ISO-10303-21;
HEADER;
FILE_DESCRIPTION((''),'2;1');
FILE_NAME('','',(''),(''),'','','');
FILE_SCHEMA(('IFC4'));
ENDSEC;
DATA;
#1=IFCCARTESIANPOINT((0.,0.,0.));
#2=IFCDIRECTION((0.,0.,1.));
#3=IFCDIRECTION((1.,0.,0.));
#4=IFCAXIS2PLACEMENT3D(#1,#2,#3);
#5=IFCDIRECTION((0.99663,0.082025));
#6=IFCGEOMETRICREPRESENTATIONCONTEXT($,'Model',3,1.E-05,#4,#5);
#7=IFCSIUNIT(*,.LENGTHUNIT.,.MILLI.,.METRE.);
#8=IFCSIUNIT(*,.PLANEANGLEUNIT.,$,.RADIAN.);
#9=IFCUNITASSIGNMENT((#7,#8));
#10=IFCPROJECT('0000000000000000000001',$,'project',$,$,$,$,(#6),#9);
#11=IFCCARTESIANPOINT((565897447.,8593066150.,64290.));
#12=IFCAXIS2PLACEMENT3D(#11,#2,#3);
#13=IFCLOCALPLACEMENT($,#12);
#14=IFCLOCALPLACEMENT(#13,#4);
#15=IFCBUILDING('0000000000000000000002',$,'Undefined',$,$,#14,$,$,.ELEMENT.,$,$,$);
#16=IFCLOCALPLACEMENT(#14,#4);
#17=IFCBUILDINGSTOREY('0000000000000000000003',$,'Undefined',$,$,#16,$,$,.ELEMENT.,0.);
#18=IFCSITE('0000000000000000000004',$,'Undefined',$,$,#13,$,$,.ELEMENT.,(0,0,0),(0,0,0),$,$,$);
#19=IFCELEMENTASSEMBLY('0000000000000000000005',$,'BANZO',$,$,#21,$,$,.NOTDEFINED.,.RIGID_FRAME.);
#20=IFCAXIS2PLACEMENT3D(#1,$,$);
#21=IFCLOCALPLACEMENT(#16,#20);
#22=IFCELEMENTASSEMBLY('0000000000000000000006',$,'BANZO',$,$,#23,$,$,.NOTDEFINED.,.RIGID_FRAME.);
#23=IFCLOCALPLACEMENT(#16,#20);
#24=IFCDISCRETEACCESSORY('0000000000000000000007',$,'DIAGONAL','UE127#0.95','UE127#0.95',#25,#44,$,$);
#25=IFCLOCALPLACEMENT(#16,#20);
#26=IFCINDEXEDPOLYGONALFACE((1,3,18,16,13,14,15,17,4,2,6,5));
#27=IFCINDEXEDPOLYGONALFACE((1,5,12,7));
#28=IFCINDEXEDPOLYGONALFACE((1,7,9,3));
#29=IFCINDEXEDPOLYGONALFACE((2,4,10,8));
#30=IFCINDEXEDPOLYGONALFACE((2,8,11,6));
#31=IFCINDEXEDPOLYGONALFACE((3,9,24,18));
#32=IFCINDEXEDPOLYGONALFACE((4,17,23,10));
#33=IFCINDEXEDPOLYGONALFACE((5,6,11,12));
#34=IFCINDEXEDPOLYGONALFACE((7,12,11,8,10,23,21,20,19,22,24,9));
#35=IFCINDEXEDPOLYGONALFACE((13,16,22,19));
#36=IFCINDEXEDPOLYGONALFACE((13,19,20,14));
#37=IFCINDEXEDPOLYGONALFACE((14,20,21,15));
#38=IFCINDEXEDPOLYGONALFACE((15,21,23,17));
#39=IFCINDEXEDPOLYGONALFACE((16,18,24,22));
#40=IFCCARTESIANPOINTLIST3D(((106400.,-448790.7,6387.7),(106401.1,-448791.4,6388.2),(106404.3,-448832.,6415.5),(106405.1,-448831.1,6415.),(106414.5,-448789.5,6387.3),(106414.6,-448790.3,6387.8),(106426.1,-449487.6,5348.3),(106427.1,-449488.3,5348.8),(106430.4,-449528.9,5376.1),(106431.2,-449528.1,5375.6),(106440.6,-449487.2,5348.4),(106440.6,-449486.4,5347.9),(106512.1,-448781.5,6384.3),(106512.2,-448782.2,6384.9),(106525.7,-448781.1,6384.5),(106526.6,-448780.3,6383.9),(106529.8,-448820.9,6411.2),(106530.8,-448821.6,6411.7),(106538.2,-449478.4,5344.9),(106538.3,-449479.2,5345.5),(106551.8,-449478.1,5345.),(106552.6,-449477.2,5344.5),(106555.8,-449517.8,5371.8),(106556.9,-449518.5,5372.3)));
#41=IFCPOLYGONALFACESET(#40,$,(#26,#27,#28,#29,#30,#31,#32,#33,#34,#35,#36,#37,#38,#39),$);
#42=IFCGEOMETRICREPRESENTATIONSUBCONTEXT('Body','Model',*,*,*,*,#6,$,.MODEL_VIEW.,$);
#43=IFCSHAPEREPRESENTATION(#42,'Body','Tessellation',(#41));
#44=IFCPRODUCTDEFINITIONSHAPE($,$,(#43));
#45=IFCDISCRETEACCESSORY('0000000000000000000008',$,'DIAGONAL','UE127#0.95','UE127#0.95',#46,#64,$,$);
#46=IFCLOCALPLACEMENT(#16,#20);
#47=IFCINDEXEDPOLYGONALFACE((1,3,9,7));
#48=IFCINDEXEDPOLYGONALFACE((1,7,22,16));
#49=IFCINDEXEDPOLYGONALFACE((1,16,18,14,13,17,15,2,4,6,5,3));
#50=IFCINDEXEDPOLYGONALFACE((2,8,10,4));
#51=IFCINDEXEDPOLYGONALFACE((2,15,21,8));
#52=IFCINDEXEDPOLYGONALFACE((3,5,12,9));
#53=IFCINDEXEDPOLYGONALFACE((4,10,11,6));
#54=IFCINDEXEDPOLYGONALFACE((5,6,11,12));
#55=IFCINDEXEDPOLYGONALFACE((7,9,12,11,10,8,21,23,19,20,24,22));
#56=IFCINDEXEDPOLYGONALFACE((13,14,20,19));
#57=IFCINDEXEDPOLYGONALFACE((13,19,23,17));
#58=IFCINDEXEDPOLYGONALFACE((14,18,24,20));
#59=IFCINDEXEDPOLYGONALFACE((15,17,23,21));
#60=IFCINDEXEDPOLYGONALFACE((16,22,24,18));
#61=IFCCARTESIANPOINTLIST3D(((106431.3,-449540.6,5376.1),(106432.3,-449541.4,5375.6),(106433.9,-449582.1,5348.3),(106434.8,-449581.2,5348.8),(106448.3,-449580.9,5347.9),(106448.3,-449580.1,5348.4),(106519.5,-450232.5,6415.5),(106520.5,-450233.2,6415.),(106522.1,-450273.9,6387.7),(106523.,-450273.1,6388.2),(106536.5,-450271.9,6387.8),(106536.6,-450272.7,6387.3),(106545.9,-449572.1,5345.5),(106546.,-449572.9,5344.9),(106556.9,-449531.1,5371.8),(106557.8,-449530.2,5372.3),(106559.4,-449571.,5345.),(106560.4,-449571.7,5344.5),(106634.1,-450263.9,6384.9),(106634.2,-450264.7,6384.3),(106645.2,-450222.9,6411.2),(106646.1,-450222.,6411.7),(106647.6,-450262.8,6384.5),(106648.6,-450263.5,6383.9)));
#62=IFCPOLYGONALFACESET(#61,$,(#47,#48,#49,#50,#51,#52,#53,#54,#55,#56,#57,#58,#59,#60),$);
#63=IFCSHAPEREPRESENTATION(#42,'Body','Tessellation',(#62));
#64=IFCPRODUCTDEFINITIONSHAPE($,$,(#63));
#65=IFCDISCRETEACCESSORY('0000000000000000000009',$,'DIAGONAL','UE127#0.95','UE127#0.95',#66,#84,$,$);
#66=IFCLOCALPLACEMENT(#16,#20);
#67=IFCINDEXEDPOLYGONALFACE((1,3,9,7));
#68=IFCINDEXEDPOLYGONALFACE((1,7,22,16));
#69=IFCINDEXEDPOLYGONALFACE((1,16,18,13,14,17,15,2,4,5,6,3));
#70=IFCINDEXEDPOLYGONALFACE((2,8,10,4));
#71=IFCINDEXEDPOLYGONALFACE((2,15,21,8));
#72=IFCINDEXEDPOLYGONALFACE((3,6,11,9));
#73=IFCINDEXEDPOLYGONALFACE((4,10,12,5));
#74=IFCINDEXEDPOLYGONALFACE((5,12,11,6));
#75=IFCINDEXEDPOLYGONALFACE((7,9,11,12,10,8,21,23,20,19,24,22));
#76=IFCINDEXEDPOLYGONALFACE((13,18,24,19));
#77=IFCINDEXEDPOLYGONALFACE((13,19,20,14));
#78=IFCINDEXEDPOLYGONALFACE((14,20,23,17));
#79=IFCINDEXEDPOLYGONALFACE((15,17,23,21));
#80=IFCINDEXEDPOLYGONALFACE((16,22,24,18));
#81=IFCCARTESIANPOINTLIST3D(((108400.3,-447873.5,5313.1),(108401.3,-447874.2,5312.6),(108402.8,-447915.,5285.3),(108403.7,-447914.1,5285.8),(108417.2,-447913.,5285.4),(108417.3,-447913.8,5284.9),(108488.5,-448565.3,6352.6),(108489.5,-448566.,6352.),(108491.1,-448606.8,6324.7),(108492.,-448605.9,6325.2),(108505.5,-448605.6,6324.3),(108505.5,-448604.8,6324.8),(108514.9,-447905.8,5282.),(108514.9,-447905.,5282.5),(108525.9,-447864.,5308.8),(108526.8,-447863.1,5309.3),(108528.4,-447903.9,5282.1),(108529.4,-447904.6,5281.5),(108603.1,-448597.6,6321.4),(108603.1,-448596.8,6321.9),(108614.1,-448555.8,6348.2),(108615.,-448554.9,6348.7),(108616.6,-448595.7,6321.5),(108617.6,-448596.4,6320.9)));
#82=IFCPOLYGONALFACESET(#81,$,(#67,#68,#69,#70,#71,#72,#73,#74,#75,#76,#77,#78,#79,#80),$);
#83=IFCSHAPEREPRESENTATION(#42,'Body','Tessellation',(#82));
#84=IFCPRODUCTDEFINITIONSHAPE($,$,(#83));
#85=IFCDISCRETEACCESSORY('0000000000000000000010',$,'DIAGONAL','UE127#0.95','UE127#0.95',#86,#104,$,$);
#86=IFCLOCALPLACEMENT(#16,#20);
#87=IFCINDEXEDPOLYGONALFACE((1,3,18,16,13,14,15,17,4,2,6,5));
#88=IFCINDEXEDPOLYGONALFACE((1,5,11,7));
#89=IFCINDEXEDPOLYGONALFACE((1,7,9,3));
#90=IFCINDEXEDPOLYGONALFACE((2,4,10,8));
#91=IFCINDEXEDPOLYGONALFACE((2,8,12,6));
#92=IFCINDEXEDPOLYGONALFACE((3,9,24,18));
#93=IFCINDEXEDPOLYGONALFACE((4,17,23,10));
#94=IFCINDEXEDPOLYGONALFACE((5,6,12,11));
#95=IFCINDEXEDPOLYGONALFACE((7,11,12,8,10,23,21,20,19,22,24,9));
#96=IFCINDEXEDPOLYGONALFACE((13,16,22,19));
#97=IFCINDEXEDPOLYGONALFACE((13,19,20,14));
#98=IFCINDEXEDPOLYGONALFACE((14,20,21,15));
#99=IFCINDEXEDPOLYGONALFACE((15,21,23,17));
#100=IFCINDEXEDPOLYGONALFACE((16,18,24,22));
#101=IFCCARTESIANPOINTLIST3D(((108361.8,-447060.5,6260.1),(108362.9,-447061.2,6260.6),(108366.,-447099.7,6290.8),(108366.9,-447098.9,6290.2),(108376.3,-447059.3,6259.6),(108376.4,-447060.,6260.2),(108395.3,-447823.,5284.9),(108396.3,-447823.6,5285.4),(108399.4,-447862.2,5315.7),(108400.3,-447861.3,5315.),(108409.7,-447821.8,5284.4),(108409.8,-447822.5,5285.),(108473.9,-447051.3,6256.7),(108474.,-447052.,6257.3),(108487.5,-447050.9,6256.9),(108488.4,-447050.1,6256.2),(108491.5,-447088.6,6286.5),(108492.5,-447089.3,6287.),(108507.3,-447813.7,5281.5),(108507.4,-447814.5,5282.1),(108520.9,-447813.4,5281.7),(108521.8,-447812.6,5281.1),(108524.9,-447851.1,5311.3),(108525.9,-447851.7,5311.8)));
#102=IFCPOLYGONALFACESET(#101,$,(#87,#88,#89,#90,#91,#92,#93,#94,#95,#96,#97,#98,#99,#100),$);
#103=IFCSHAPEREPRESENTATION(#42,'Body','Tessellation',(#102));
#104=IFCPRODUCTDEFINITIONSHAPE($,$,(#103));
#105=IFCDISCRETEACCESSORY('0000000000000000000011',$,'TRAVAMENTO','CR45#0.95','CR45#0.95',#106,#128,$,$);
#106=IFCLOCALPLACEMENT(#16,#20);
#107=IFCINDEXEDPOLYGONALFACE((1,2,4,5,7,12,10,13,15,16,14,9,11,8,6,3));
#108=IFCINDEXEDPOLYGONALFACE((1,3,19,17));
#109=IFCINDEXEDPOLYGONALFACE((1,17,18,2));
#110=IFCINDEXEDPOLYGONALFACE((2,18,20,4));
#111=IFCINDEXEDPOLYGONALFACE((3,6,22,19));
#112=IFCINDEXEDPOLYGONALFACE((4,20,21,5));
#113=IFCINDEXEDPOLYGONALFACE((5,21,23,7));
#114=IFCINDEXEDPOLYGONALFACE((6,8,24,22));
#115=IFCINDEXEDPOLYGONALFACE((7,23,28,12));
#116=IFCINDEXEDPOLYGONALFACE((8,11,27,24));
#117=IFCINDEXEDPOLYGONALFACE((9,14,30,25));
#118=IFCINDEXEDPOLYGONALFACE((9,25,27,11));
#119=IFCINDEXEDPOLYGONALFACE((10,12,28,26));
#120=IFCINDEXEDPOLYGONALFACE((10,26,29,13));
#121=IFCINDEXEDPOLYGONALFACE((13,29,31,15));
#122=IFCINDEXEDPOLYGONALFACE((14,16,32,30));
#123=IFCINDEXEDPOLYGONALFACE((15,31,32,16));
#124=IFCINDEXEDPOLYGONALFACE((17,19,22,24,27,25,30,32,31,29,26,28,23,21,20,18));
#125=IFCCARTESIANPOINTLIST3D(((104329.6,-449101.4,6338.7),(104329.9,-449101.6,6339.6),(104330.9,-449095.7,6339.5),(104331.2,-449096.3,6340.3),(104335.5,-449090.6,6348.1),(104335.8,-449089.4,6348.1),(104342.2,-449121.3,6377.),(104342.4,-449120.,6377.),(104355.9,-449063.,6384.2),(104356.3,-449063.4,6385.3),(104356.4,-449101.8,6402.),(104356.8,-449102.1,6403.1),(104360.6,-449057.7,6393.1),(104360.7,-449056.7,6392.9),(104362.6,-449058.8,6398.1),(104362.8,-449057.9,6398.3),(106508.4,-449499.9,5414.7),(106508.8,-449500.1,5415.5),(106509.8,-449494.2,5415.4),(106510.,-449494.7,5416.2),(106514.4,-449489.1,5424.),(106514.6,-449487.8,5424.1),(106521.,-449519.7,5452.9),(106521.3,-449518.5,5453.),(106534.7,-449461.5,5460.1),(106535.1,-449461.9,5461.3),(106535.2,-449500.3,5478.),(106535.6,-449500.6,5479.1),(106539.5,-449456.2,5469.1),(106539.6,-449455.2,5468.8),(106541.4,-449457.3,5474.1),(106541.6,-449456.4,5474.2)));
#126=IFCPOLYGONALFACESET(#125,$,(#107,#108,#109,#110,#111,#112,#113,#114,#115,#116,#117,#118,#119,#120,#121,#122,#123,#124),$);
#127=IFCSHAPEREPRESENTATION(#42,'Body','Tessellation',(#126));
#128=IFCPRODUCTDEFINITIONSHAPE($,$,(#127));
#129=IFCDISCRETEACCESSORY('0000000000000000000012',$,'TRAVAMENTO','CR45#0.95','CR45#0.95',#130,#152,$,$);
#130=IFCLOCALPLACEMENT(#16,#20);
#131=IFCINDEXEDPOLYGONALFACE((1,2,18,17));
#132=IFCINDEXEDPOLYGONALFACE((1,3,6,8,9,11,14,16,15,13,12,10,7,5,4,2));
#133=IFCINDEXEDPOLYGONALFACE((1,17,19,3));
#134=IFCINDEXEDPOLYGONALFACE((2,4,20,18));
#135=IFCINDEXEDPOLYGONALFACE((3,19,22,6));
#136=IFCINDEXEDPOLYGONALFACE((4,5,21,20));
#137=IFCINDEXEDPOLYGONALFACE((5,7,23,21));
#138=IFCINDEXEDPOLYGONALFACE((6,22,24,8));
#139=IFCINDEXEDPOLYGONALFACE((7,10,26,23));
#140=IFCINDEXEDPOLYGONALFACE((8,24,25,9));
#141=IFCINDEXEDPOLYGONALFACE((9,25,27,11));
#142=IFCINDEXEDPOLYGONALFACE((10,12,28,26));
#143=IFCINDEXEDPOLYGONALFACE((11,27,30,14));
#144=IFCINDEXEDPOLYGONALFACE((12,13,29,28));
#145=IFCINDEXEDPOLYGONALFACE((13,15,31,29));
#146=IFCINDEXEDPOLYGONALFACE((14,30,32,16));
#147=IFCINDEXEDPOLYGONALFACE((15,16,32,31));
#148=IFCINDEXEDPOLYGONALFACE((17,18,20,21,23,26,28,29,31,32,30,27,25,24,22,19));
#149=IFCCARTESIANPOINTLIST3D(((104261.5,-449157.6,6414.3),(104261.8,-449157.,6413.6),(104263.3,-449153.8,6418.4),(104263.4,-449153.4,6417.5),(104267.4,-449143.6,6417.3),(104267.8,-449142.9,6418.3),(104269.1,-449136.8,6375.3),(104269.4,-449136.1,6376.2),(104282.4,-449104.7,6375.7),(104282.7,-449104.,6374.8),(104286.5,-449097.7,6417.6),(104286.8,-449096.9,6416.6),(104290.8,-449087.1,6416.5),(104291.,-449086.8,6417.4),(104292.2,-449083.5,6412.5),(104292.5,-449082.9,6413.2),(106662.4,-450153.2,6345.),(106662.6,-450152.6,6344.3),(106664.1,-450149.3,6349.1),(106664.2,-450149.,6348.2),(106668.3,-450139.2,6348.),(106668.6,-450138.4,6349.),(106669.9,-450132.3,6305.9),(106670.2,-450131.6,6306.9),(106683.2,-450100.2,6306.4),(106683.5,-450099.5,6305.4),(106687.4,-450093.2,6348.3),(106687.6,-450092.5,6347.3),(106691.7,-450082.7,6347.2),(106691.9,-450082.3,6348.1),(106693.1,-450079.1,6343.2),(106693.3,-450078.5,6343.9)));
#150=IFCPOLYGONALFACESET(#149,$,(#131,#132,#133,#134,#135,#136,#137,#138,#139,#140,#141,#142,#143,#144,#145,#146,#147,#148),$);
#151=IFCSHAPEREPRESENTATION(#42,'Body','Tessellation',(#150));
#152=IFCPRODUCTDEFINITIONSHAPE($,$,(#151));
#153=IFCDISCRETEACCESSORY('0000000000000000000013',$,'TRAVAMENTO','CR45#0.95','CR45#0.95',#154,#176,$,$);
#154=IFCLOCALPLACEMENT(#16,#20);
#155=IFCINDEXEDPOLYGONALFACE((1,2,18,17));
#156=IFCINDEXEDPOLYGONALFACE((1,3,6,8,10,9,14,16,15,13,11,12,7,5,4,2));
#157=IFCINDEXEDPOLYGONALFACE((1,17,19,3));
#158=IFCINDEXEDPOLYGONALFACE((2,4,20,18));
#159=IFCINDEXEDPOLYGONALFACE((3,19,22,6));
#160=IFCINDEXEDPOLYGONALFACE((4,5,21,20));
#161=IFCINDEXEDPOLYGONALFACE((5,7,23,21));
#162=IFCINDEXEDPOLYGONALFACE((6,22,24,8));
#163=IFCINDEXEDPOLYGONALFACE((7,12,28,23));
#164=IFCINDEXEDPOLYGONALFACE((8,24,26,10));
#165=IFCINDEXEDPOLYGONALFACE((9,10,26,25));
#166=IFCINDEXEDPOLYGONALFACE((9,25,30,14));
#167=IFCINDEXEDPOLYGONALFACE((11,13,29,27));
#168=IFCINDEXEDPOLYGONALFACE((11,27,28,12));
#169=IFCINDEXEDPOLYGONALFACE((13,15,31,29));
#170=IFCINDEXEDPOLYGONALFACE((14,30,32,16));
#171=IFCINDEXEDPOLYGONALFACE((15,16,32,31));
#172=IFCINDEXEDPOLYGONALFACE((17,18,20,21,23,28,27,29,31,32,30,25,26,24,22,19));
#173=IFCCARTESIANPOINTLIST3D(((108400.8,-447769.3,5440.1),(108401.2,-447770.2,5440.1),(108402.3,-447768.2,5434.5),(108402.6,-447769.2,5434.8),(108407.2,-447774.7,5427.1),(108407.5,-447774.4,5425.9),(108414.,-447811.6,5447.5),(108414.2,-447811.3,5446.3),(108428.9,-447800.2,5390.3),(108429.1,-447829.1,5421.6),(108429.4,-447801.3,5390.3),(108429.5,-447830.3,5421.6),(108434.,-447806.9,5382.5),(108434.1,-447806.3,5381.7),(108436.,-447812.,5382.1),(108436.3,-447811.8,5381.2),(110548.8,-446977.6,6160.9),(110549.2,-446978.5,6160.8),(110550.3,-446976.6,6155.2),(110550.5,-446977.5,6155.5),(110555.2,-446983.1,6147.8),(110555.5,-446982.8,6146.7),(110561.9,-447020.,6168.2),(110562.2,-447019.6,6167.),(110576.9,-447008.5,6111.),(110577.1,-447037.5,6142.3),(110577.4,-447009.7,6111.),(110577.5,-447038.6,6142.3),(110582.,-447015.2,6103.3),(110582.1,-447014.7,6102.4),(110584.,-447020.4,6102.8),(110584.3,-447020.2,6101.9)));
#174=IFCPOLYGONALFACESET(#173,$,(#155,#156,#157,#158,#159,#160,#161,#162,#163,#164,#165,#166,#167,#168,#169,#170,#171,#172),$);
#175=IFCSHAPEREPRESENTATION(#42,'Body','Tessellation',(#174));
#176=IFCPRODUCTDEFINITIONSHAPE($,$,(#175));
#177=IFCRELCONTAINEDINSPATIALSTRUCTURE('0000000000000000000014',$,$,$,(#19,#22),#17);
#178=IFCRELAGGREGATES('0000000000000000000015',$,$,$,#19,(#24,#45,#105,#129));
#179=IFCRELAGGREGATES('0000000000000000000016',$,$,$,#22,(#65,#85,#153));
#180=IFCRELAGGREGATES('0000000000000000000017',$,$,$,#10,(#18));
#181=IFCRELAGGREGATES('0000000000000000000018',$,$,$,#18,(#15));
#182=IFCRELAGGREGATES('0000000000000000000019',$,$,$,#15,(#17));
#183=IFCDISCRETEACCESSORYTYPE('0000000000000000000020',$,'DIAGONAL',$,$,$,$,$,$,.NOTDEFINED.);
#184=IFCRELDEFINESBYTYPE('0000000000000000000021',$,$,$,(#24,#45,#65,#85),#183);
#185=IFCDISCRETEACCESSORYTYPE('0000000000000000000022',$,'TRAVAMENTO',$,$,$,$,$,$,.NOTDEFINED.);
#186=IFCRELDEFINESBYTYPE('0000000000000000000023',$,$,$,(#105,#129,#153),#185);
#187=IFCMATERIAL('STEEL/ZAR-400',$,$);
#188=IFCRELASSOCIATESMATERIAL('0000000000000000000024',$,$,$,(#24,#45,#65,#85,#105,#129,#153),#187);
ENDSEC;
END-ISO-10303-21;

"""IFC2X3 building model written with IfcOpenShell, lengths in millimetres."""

from ifc_helpers import new_model, si_unit, direction, frame, frame_2d, origin_with_axes, place, context, subcontext, project, spatial, polyline, c_section, outline, extrude, material, type_object, element, aggregate, save


model = new_model("IFC2X3")

# Units and contexts
model_context = context("Model", 3, precision=1e-05, world=origin_with_axes(), true_north=direction((0.99663, 0.082025)))
body_context = subcontext(model_context, "Body", "Model", "MODEL_VIEW")
ifc_project = project(units=[si_unit("LENGTHUNIT", "METRE", prefix="MILLI"), si_unit("PLANEANGLEUNIT", "RADIAN")], contexts=[model_context])

# Site, building, storey
site_placement = place(None, frame((565897447.0, 8593066150.0, 64290.0), z_axis=(0.0, 0.0, 1.0), x_axis=(1.0, 0.0, 0.0)))
site = spatial("IfcSite", under=ifc_project, at=site_placement, Name="Undefined", CompositionType="ELEMENT", RefLatitude=(0, 0, 0), RefLongitude=(0, 0, 0))
building_placement = place(site_placement, origin_with_axes())
building = spatial("IfcBuilding", under=site, at=building_placement, Name="Undefined", CompositionType="ELEMENT")
storey_placement = place(building_placement, origin_with_axes())
storey = spatial("IfcBuildingStorey", under=building, at=storey_placement, Name="Undefined", CompositionType="ELEMENT", Elevation=0.0)

# Shared definitions
ifc_material_1 = material(Name="STEEL/ZAR-400")

# Element assemblies
assembly_1_placement = place(storey_placement, origin_with_axes())
assembly_1 = element("IfcElementAssembly", 1, at=assembly_1_placement, inside=storey, Name="BANZO", AssemblyPlace="NOTDEFINED", PredefinedType="RIGID_FRAME")
assembly_2_placement = place(storey_placement, origin_with_axes())
assembly_2 = element("IfcElementAssembly", 2, at=assembly_2_placement, inside=storey, Name="BANZO", AssemblyPlace="NOTDEFINED", PredefinedType="RIGID_FRAME")

# Discrete accessories
discrete_accessory_type_1 = type_object("IfcDiscreteAccessoryType", Name="DIAGONAL")
discrete_accessory_1_placement = place(assembly_1_placement, frame((106465.4, -448806.1, 6399.7), z_axis=(-0.996182, -0.081989, 0.029987), x_axis=(0.020829, -0.556784, -0.830396)))
discrete_accessory_1 = element("IfcDiscreteAccessory", 3, at=discrete_accessory_1_placement, type_object=discrete_accessory_type_1, material=ifc_material_1, Name="DIAGONAL", Description="UE127#0.95", ObjectType="UE127#0.95", context=body_context, shape_type="SweptSolid", body=[
    extrude(c_section(Depth=127.0, Width=50.0, WallThickness=0.9, Girth=14.5, at=frame_2d((0.0, 0.0), x_axis=(1.0, 0.0))), frame((1251.7, 0.0, 0.0), z_axis=(-1.0, 0.0, 0.0), x_axis=(0.0, -1.0, 0.0)), (0.0, 0.0, 1.0), 1251.7),
])
discrete_accessory_2_placement = place(assembly_1_placement, frame((106495.9, -449556.2, 5360.3), z_axis=(-0.996182, -0.081989, 0.029987), x_axis=(0.070485, -0.552697, 0.830396)))
discrete_accessory_2 = element("IfcDiscreteAccessory", 4, at=discrete_accessory_2_placement, type_object=discrete_accessory_type_1, material=ifc_material_1, Name="DIAGONAL", Description="UE127#0.95", ObjectType="UE127#0.95", context=body_context, shape_type="SweptSolid", body=[
    extrude(c_section(Depth=127.0, Width=50.0, WallThickness=0.9, Girth=14.5, at=frame_2d((0.0, 0.0), x_axis=(1.0, 0.0))), frame((1251.7, 0.0, 0.0), z_axis=(-1.0, 0.0, 0.0), x_axis=(0.0, -1.0, 0.0)), (0.0, 0.0, 1.0), 1251.7),
])
discrete_accessory_3_placement = place(assembly_2_placement, frame((108464.8, -447889.0, 5297.3), z_axis=(-0.996182, -0.081989, 0.029987), x_axis=(0.070485, -0.552697, 0.830396)))
discrete_accessory_3 = element("IfcDiscreteAccessory", 5, at=discrete_accessory_3_placement, type_object=discrete_accessory_type_1, material=ifc_material_1, Name="DIAGONAL", Description="UE127#0.95", ObjectType="UE127#0.95", context=body_context, shape_type="SweptSolid", body=[
    extrude(c_section(Depth=127.0, Width=50.0, WallThickness=0.9, Girth=14.5, at=frame_2d((0.0, 0.0), x_axis=(1.0, 0.0))), frame((1251.7, 0.0, 0.0), z_axis=(-1.0, 0.0, 0.0), x_axis=(0.0, -1.0, 0.0)), (0.0, 0.0, 1.0), 1251.7),
])
discrete_accessory_4_placement = place(assembly_2_placement, frame((108427.2, -447074.9, 6273.5), z_axis=(-0.996182, -0.081989, 0.029987), x_axis=(0.026972, -0.615733, -0.787493)))
discrete_accessory_4 = element("IfcDiscreteAccessory", 6, at=discrete_accessory_4_placement, type_object=discrete_accessory_type_1, material=ifc_material_1, Name="DIAGONAL", Description="UE127#0.95", ObjectType="UE127#0.95", context=body_context, shape_type="SweptSolid", body=[
    extrude(c_section(Depth=127.0, Width=50.0, WallThickness=0.9, Girth=14.5, at=frame_2d((0.0, 0.0), x_axis=(1.0, 0.0))), frame((1238.3, 0.0, 0.0), z_axis=(-1.0, 0.0, 0.0), x_axis=(0.0, -1.0, 0.0)), (0.0, 0.0, 1.0), 1238.3),
])
discrete_accessory_type_2 = type_object("IfcDiscreteAccessoryType", Name="TRAVAMENTO")
discrete_accessory_5_placement = place(assembly_1_placement, frame((106526.4, -449492.6, 5453.8), z_axis=(0.084779, -0.826601, 0.556366), x_axis=(-0.907854, 0.16603, 0.385013)))
discrete_accessory_5 = element("IfcDiscreteAccessory", 7, at=discrete_accessory_5_placement, type_object=discrete_accessory_type_2, material=ifc_material_1, Name="TRAVAMENTO", Description="CR45#0.95", ObjectType="CR45#0.95", context=body_context, shape_type="SweptSolid", body=[
    extrude(outline(polyline([(-35.5, -20.5), (-24.9, -20.5), (-17.4, 21.5), (18.1, 21.5), (25.6, -20.5), (36.2, -20.5), (40.1, -16.6), (40.8, -17.3), (36.6, -21.5), (24.8, -21.5), (17.3, 20.5), (-16.6, 20.5), (-24.1, -21.5), (-35.9, -21.5), (-40.1, -17.3), (-39.4, -16.6), (-35.5, -20.5)])), frame((2400.0, 0.0, 0.0), z_axis=(-1.0, 0.0, 0.0), x_axis=(0.0, -1.0, 0.0)), (0.0, 0.0, 1.0), 2400.0),
])
discrete_accessory_6_placement = place(assembly_1_placement, frame((106677.5, -450115.6, 6327.1), z_axis=(-0.029884, -0.00246, -0.99955), x_axis=(-0.923403, 0.382903, 0.026665)))
discrete_accessory_6 = element("IfcDiscreteAccessory", 8, at=discrete_accessory_6_placement, type_object=discrete_accessory_type_2, material=ifc_material_1, Name="TRAVAMENTO", Description="CR45#0.95", ObjectType="CR45#0.95", context=body_context, shape_type="SweptSolid", body=[
    extrude(outline(polyline([(-35.5, -20.5), (-24.9, -20.5), (-17.4, 21.5), (18.1, 21.5), (25.6, -20.5), (36.2, -20.5), (40.1, -16.6), (40.8, -17.3), (36.6, -21.5), (24.8, -21.5), (17.3, 20.5), (-16.6, 20.5), (-24.1, -21.5), (-35.9, -21.5), (-40.1, -17.3), (-39.4, -16.6), (-35.5, -20.5)])), frame((2600.0, 0.0, 0.0), z_axis=(-1.0, 0.0, 0.0), x_axis=(0.0, -1.0, 0.0)), (0.0, 0.0, 1.0), 2600.0),
])
aggregate(assembly_1, [discrete_accessory_1, discrete_accessory_2, discrete_accessory_5, discrete_accessory_6])
discrete_accessory_7_placement = place(assembly_2_placement, frame((108419.8, -447803.9, 5421.6), z_axis=(0.082412, -0.78389, 0.615407), x_axis=(0.894995, 0.329851, 0.300303)))
discrete_accessory_7 = element("IfcDiscreteAccessory", 9, at=discrete_accessory_7_placement, type_object=discrete_accessory_type_2, material=ifc_material_1, Name="TRAVAMENTO", Description="CR45#0.95", ObjectType="CR45#0.95", context=body_context, shape_type="SweptSolid", body=[
    extrude(outline(polyline([(-35.5, -20.5), (-24.9, -20.5), (-17.4, 21.5), (18.1, 21.5), (25.6, -20.5), (36.2, -20.5), (40.1, -16.6), (40.8, -17.3), (36.6, -21.5), (24.8, -21.5), (17.3, 20.5), (-16.6, 20.5), (-24.1, -21.5), (-35.9, -21.5), (-40.1, -17.3), (-39.4, -16.6), (-35.5, -20.5)])), frame((2400.0, 0.0, 0.0), z_axis=(-1.0, 0.0, 0.0), x_axis=(0.0, -1.0, 0.0)), (0.0, 0.0, 1.0), 2400.0),
])
aggregate(assembly_2, [discrete_accessory_3, discrete_accessory_4, discrete_accessory_7])

save(model, "model.ifc")
